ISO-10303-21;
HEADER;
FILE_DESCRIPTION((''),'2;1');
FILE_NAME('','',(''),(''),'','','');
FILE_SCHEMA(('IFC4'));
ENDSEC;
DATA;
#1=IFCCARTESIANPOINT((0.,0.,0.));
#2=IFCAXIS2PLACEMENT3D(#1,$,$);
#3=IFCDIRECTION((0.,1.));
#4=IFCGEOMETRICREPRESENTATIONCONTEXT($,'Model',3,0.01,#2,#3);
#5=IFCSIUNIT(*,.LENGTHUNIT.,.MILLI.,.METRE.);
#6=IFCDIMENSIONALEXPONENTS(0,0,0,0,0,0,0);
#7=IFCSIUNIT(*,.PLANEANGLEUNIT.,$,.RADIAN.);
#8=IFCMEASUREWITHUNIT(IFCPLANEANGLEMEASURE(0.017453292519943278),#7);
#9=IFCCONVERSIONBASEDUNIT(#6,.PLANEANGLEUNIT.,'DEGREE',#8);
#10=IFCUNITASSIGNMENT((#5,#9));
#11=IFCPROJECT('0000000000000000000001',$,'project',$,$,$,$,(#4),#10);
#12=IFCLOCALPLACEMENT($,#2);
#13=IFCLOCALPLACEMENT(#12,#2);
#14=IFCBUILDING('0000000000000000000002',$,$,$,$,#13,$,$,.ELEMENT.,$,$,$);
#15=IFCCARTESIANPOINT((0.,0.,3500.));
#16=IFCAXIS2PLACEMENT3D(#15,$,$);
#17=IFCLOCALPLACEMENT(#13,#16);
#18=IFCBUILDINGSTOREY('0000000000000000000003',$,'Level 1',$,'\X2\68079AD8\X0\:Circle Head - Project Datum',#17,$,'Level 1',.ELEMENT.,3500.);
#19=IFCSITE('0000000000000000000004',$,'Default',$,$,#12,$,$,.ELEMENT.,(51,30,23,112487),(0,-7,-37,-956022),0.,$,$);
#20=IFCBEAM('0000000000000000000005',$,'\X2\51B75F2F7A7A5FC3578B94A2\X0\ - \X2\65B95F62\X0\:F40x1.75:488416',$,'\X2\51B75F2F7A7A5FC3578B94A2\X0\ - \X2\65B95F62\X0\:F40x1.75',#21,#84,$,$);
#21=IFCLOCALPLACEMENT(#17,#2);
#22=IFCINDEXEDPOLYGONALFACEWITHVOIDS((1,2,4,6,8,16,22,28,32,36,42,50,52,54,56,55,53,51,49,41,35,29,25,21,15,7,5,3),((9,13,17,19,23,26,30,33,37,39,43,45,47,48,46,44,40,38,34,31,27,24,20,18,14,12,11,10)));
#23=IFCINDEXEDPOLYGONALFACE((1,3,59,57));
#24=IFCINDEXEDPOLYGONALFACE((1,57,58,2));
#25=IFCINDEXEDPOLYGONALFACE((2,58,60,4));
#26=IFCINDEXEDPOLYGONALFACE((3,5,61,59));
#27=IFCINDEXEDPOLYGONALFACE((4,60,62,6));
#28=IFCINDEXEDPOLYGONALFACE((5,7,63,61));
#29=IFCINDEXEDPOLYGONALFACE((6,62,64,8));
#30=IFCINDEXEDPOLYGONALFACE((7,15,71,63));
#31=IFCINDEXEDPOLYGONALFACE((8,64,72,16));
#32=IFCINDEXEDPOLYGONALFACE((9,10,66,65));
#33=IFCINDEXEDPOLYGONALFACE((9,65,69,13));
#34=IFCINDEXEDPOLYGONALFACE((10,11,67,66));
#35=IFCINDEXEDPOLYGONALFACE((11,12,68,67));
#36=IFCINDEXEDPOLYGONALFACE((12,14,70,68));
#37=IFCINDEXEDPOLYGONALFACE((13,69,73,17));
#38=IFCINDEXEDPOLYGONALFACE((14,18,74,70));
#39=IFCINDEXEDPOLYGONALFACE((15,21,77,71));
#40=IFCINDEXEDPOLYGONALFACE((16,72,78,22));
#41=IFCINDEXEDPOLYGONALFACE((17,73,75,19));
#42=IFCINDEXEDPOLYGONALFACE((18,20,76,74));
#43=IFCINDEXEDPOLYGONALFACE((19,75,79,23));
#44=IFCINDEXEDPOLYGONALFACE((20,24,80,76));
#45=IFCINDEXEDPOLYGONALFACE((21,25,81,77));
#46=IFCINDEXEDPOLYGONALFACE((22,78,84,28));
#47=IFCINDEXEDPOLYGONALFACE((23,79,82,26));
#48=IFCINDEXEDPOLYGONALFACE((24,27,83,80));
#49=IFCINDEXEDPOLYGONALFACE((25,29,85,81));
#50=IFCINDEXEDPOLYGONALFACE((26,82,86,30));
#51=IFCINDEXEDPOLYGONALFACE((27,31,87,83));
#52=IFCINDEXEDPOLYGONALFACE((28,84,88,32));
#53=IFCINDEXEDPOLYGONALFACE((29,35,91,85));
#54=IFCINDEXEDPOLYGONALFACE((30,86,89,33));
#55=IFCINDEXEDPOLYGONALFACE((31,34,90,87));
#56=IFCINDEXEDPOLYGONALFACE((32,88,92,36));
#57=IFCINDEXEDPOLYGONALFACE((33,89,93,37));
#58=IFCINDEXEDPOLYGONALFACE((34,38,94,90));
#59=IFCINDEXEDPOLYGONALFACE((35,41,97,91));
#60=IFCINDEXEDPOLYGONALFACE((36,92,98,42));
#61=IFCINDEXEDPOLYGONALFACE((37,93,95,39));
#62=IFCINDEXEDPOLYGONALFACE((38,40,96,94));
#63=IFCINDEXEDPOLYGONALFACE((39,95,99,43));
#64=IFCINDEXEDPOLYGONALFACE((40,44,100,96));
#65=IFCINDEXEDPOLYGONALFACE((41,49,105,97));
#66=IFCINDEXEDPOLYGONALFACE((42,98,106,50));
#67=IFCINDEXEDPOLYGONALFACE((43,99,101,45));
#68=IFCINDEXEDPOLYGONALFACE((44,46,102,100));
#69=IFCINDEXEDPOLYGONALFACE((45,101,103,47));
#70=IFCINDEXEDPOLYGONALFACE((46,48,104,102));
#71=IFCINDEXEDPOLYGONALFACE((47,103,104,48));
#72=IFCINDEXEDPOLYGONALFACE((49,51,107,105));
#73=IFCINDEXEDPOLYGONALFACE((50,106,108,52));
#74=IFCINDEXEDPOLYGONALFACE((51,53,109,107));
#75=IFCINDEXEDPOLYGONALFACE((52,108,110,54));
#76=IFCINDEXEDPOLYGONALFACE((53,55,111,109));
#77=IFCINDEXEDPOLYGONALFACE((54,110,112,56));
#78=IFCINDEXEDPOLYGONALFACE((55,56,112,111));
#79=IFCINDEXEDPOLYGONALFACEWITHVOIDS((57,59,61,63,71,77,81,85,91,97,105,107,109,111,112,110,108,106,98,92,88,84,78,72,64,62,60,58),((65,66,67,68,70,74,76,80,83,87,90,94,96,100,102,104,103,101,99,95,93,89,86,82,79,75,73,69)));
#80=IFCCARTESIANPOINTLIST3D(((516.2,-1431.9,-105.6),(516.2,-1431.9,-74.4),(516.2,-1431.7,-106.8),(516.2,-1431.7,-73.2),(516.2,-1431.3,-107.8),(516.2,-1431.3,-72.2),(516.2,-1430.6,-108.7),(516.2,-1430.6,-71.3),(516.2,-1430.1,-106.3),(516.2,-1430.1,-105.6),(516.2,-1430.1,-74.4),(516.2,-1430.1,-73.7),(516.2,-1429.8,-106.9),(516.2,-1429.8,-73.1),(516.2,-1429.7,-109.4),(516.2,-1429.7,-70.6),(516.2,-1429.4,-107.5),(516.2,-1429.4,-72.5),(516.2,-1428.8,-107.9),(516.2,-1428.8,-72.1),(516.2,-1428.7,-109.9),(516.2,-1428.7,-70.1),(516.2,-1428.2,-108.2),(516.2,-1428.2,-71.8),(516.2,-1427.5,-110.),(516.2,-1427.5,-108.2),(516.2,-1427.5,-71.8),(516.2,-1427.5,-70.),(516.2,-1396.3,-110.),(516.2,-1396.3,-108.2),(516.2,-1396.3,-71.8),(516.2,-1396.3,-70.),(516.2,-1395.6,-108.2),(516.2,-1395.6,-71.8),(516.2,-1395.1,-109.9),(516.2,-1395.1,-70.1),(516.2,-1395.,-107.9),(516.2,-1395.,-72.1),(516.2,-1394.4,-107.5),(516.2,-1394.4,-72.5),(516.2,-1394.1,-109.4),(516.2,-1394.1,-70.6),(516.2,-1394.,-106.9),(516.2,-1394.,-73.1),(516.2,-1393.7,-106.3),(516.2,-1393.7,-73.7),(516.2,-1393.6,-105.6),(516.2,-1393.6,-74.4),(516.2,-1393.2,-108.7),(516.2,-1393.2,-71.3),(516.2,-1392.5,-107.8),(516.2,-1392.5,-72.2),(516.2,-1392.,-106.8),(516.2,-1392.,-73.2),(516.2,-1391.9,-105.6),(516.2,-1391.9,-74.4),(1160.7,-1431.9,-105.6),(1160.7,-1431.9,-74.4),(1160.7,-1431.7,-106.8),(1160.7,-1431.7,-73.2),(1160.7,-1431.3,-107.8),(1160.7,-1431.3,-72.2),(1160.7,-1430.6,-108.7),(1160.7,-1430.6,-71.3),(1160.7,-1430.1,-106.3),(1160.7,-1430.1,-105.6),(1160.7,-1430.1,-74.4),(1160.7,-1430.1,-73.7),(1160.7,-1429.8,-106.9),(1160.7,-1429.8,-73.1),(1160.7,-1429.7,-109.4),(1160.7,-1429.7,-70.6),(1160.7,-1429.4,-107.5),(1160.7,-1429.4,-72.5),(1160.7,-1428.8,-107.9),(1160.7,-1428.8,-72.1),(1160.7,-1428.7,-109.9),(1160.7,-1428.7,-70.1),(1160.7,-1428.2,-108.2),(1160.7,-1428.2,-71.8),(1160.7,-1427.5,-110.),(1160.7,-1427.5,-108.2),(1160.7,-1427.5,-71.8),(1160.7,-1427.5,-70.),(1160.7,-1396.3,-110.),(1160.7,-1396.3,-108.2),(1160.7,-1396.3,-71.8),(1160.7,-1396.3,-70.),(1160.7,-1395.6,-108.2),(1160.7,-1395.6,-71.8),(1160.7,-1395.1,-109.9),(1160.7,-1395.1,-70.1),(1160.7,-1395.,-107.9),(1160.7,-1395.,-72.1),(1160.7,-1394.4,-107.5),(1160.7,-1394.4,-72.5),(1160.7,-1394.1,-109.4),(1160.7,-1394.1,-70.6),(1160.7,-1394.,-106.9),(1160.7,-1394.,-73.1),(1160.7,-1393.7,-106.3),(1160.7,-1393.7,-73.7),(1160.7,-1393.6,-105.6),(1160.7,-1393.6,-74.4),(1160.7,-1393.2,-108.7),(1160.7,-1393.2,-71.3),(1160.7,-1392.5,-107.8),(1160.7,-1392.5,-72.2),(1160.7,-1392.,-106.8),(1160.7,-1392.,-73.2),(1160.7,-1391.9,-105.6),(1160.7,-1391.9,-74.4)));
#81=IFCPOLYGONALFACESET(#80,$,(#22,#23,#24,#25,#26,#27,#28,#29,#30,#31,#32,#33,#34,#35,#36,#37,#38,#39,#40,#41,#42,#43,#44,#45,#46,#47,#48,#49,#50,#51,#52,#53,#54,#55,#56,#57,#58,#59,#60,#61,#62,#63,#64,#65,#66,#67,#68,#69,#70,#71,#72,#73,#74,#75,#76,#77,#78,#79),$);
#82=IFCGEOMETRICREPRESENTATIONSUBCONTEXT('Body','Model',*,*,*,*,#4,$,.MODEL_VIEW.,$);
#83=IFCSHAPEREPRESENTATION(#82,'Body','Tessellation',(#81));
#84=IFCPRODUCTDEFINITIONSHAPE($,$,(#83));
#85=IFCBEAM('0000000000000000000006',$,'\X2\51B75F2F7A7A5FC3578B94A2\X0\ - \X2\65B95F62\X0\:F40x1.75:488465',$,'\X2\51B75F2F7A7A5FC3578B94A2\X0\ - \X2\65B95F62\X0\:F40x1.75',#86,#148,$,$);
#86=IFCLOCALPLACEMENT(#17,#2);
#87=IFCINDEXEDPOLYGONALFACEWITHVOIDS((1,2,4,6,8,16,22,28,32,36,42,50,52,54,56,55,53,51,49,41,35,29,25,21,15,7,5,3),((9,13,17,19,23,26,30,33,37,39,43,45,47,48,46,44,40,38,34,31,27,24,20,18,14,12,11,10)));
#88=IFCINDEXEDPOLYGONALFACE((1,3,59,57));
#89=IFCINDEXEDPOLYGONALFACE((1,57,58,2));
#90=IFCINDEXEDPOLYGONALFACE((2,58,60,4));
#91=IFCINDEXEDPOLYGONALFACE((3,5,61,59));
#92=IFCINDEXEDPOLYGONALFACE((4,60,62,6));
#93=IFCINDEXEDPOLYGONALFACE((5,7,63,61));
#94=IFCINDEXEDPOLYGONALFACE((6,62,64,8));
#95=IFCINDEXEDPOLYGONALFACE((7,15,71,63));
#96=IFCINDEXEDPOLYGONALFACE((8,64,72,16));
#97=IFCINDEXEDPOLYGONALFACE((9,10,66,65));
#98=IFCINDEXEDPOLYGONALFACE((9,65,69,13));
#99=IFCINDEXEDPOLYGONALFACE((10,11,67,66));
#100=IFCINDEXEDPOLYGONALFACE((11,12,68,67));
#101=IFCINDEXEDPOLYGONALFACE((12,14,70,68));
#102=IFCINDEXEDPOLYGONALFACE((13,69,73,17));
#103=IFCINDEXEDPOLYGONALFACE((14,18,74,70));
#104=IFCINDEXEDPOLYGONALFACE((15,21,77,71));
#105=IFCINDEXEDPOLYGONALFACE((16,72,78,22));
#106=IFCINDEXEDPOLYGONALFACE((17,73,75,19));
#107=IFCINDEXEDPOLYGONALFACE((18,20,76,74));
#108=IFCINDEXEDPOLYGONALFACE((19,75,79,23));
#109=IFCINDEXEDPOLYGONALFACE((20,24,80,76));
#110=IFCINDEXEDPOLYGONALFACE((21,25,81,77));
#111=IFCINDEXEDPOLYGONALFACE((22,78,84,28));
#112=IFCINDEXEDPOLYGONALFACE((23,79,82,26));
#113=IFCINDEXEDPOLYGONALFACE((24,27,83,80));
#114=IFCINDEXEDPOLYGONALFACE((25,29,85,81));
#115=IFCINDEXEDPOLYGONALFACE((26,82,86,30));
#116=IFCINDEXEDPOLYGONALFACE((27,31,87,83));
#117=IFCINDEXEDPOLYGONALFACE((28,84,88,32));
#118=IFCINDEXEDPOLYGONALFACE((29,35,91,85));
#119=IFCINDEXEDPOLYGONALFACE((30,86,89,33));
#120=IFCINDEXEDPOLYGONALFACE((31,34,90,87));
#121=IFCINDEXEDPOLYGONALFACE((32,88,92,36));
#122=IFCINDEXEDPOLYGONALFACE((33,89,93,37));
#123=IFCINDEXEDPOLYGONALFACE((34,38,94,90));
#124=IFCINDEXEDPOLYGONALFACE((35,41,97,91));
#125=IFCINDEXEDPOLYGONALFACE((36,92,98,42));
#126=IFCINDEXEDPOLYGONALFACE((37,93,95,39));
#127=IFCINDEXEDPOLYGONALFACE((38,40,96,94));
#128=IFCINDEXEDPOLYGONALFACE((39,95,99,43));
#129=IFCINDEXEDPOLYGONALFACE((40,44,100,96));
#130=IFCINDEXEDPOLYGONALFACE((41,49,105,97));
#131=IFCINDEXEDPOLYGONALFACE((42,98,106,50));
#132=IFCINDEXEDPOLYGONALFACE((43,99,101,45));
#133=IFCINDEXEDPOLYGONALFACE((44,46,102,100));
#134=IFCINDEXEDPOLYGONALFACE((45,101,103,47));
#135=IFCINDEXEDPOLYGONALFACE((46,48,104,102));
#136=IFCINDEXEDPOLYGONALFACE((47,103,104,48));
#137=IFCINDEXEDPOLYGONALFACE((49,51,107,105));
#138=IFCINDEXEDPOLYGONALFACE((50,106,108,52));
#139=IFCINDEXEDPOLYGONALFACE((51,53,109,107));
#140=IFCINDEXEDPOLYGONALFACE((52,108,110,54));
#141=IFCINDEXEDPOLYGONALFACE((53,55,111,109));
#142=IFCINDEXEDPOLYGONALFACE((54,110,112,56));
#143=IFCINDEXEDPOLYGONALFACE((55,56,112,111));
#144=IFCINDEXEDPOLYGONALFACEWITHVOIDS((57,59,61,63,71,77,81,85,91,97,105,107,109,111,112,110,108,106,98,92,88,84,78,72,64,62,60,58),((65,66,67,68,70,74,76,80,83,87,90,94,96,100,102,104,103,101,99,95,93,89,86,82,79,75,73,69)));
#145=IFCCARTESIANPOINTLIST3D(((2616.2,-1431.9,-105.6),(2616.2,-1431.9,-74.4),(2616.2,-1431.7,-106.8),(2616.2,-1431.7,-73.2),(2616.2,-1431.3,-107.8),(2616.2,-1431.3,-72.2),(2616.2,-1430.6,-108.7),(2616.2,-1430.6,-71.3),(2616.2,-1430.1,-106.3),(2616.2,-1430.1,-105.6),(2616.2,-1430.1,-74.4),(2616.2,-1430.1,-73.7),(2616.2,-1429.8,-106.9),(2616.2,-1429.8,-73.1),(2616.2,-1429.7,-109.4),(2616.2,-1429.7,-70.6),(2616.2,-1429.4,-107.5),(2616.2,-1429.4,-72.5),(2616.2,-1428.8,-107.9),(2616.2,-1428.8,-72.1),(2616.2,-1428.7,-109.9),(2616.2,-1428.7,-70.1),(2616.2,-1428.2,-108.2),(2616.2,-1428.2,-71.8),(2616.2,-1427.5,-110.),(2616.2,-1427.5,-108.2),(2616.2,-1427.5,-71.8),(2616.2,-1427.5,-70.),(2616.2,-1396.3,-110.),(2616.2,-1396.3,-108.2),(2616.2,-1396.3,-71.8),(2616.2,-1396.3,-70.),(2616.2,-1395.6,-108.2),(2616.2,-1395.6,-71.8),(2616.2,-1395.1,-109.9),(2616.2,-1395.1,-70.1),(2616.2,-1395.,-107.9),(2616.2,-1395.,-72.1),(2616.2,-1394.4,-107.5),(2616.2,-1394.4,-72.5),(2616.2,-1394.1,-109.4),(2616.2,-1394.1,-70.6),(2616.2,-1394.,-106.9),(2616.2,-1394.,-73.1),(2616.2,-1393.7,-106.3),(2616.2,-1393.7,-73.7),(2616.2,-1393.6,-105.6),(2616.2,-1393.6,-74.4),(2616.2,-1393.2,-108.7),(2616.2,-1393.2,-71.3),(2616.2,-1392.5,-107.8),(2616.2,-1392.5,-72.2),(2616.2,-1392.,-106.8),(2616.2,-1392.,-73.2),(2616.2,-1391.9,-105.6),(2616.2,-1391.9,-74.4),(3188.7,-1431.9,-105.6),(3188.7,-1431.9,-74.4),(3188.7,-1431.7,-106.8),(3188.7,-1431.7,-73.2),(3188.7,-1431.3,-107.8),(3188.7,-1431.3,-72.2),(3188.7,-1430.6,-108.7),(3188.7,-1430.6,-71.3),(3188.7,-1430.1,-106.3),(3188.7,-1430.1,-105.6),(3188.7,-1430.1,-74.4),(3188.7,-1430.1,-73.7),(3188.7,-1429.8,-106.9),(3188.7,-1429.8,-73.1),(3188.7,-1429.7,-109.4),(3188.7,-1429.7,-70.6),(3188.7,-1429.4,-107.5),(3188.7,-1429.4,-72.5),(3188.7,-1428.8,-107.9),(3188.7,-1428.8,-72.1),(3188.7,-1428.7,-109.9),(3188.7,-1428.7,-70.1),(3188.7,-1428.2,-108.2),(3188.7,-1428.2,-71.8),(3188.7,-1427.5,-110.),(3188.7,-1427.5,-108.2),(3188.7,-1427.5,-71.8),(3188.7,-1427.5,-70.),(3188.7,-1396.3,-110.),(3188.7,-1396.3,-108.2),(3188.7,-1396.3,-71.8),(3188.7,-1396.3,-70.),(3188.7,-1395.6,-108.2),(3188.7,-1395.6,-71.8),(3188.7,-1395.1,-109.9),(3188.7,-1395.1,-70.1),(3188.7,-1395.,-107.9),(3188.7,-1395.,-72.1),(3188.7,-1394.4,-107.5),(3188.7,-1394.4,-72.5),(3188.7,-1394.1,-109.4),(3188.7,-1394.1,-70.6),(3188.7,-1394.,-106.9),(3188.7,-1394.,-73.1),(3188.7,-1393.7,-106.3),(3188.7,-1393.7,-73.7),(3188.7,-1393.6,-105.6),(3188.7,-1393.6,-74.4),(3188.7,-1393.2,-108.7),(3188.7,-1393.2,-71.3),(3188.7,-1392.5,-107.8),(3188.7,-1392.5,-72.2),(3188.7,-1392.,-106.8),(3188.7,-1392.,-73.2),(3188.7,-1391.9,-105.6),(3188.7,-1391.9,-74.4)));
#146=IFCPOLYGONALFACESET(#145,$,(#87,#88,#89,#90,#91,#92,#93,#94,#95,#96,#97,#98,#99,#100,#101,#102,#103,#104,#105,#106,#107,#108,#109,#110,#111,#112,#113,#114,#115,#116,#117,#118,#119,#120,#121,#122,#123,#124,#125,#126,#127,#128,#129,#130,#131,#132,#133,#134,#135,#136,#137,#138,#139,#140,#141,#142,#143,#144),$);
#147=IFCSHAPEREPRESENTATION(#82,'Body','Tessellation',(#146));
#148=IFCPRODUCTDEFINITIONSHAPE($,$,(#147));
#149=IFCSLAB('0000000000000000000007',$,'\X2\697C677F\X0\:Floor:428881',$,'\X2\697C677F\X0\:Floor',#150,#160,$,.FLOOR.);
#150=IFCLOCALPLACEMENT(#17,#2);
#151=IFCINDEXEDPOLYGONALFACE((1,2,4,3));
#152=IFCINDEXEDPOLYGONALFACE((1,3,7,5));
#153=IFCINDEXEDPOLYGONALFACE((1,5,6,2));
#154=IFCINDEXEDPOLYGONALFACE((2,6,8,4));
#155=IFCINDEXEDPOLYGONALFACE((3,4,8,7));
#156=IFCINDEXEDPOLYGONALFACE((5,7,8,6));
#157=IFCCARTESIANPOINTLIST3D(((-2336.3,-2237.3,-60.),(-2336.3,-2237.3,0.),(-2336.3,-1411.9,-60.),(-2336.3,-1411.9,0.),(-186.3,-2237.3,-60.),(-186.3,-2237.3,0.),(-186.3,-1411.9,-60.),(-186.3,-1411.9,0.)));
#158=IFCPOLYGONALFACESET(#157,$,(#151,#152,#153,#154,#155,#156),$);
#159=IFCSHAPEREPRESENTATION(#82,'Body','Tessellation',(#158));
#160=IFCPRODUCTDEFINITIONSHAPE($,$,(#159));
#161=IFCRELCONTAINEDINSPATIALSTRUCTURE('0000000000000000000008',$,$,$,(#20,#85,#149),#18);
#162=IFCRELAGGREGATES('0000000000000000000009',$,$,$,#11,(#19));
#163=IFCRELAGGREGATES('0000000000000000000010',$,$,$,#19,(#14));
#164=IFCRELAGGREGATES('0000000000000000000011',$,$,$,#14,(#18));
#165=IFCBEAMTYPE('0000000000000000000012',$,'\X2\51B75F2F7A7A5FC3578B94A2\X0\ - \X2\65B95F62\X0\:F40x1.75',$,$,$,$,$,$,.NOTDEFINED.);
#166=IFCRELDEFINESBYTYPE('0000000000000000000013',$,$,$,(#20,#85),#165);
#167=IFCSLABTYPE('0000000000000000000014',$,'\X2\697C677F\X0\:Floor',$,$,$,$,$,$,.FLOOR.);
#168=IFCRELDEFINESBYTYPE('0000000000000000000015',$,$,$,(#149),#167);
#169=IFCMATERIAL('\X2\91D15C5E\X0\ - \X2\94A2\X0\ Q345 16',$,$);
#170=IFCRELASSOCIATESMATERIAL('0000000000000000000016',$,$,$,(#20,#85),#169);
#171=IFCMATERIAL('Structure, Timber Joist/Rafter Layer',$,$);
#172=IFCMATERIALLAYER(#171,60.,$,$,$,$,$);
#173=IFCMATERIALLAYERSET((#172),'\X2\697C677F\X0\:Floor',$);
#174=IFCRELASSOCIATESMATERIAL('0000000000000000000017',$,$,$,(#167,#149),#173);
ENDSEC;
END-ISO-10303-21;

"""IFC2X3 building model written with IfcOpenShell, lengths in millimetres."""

from ifc_helpers import new_model, entity, si_unit, converted_unit, direction, frame, frame_2d, origin, place, context, subcontext, project, spatial, polyline, circle_curve, parameter, trimmed, segment, composite_curve, rectangle, outline, extrude, material, layer, layer_set, layer_usage, type_object, element, save


model = new_model("IFC2X3")

# Units and contexts
model_context = context("Model", 3, precision=0.01, world=origin(), true_north=direction((0.0, 1.0)))
body_context = subcontext(model_context, "Body", "Model", "MODEL_VIEW")
ifc_project = project(units=[si_unit("LENGTHUNIT", "METRE", prefix="MILLI"), converted_unit("PLANEANGLEUNIT", "DEGREE", entity("IfcPlaneAngleMeasure", 0.017453292519943278), si_unit("PLANEANGLEUNIT", "RADIAN"), dimensions=[0, 0, 0, 0, 0, 0, 0])], contexts=[model_context])

# Site, building, storey
site_placement = place(None, origin())
site = spatial("IfcSite", under=ifc_project, at=site_placement, Name="Default", CompositionType="ELEMENT", RefLatitude=(51, 30, 23, 112487), RefLongitude=(0, -7, -37, -956022), RefElevation=0.0)
building_placement = place(site_placement, origin())
building = spatial("IfcBuilding", under=site, at=building_placement, CompositionType="ELEMENT")
storey_placement = place(building_placement, frame((0.0, 0.0, 3500.0)))
storey = spatial("IfcBuildingStorey", under=building, at=storey_placement, Name="Level 1", ObjectType="标高:Circle Head - Project Datum", LongName="Level 1", CompositionType="ELEMENT", Elevation=3500.0)

# Beams
ifc_material_1 = material(Name="金属 - 钢 Q345 16")
beam_type_1 = type_object("IfcBeamType", Name="冷弯空心型钢 - 方形:F40x1.75", PredefinedType="NOTDEFINED")
beam_1_placement = place(storey_placement, frame((548.7, -1411.9, -70.0)))
element("IfcBeam", 1, at=beam_1_placement, inside=storey, type_object=beam_type_1, material=ifc_material_1, Name="冷弯空心型钢 - 方形:F40x1.75:488416", ObjectType="冷弯空心型钢 - 方形:F40x1.75", context=body_context, shape_type="SweptSolid", body=[
    extrude(outline(composite_curve([segment(trimmed(circle_curve(frame_2d((-15.6, 15.6), x_axis=(1.0, 0.0)), 4.4), [parameter(90.0)], [parameter(180.0)], True, "PARAMETER"), True, "CONTINUOUS"), segment(polyline([(-20.0, 15.6), (-20.0, -15.6)]), True, "CONTINUOUS"), segment(trimmed(circle_curve(frame_2d((-15.6, -15.6), x_axis=(1.0, 0.0)), 4.4), [parameter(180.0)], [parameter(270.0)], True, "PARAMETER"), True, "CONTINUOUS"), segment(polyline([(-15.6, -20.0), (15.6, -20.0)]), True, "CONTINUOUS"), segment(trimmed(circle_curve(frame_2d((15.6, -15.6), x_axis=(1.0, 0.0)), 4.4), [parameter(270.0)], [parameter(0.0)], True, "PARAMETER"), True, "CONTINUOUS"), segment(polyline([(20.0, -15.6), (20.0, 15.6)]), True, "CONTINUOUS"), segment(trimmed(circle_curve(frame_2d((15.6, 15.6), x_axis=(1.0, 0.0)), 4.4), [parameter(0.0)], [parameter(90.0)], True, "PARAMETER"), True, "CONTINUOUS"), segment(polyline([(15.6, 20.0), (-15.6, 20.0)]), True, "CONTINUOUS")], self_intersect=False), holes=[composite_curve([segment(polyline([(-15.6, 18.3), (15.6, 18.3)]), True, "CONTINUOUS"), segment(trimmed(circle_curve(frame_2d((15.6, 15.6), x_axis=(1.0, 0.0)), 2.6), [parameter(0.0)], [parameter(90.0)], True, "PARAMETER"), False, "CONTINUOUS"), segment(polyline([(18.2, 15.6), (18.2, -15.6)]), True, "CONTINUOUS"), segment(trimmed(circle_curve(frame_2d((15.6, -15.6), x_axis=(1.0, 0.0)), 2.6), [parameter(270.0)], [parameter(360.0)], True, "PARAMETER"), False, "CONTINUOUS"), segment(polyline([(15.6, -18.3), (-15.6, -18.3)]), True, "CONTINUOUS"), segment(trimmed(circle_curve(frame_2d((-15.6, -15.6), x_axis=(1.0, 0.0)), 2.6), [parameter(180.0)], [parameter(270.0)], True, "PARAMETER"), False, "CONTINUOUS"), segment(polyline([(-18.3, -15.6), (-18.3, 15.6)]), True, "CONTINUOUS"), segment(trimmed(circle_curve(frame_2d((-15.6, 15.6), x_axis=(1.0, 0.0)), 2.6), [parameter(90.0)], [parameter(180.0)], True, "PARAMETER"), False, "CONTINUOUS")], self_intersect=False)]), frame((-32.5, 0.0, -20.0), z_axis=(1.0, 0.0, 0.0), x_axis=(0.0, 1.0, 0.0)), (0.0, 0.0, 1.0), 644.5),
])
beam_2_placement = place(storey_placement, frame((2618.7, -1411.9, -70.0)))
element("IfcBeam", 2, at=beam_2_placement, inside=storey, type_object=beam_type_1, material=ifc_material_1, Name="冷弯空心型钢 - 方形:F40x1.75:488465", ObjectType="冷弯空心型钢 - 方形:F40x1.75", context=body_context, shape_type="SweptSolid", body=[
    extrude(outline(composite_curve([segment(trimmed(circle_curve(frame_2d((-15.6, 15.6), x_axis=(1.0, 0.0)), 4.4), [parameter(90.0)], [parameter(180.0)], True, "PARAMETER"), True, "CONTINUOUS"), segment(polyline([(-20.0, 15.6), (-20.0, -15.6)]), True, "CONTINUOUS"), segment(trimmed(circle_curve(frame_2d((-15.6, -15.6), x_axis=(1.0, 0.0)), 4.4), [parameter(180.0)], [parameter(270.0)], True, "PARAMETER"), True, "CONTINUOUS"), segment(polyline([(-15.6, -20.0), (15.6, -20.0)]), True, "CONTINUOUS"), segment(trimmed(circle_curve(frame_2d((15.6, -15.6), x_axis=(1.0, 0.0)), 4.4), [parameter(270.0)], [parameter(0.0)], True, "PARAMETER"), True, "CONTINUOUS"), segment(polyline([(20.0, -15.6), (20.0, 15.6)]), True, "CONTINUOUS"), segment(trimmed(circle_curve(frame_2d((15.6, 15.6), x_axis=(1.0, 0.0)), 4.4), [parameter(0.0)], [parameter(90.0)], True, "PARAMETER"), True, "CONTINUOUS"), segment(polyline([(15.6, 20.0), (-15.6, 20.0)]), True, "CONTINUOUS")], self_intersect=False), holes=[composite_curve([segment(polyline([(-15.6, 18.3), (15.6, 18.3)]), True, "CONTINUOUS"), segment(trimmed(circle_curve(frame_2d((15.6, 15.6), x_axis=(1.0, 0.0)), 2.6), [parameter(0.0)], [parameter(90.0)], True, "PARAMETER"), False, "CONTINUOUS"), segment(polyline([(18.2, 15.6), (18.2, -15.6)]), True, "CONTINUOUS"), segment(trimmed(circle_curve(frame_2d((15.6, -15.6), x_axis=(1.0, 0.0)), 2.6), [parameter(270.0)], [parameter(360.0)], True, "PARAMETER"), False, "CONTINUOUS"), segment(polyline([(15.6, -18.3), (-15.6, -18.3)]), True, "CONTINUOUS"), segment(trimmed(circle_curve(frame_2d((-15.6, -15.6), x_axis=(1.0, 0.0)), 2.6), [parameter(180.0)], [parameter(270.0)], True, "PARAMETER"), False, "CONTINUOUS"), segment(polyline([(-18.3, -15.6), (-18.3, 15.6)]), True, "CONTINUOUS"), segment(trimmed(circle_curve(frame_2d((-15.6, 15.6), x_axis=(1.0, 0.0)), 2.6), [parameter(90.0)], [parameter(180.0)], True, "PARAMETER"), False, "CONTINUOUS")], self_intersect=False)]), frame((-2.5, 0.0, -20.0), z_axis=(1.0, 0.0, 0.0), x_axis=(0.0, 1.0, 0.0)), (0.0, 0.0, 1.0), 572.5),
])

# Slab
ifc_material_2 = material(Name="Structure, Timber Joist/Rafter Layer")
ifc_layer = layer(ifc_material_2, 60.0)
ifc_layer_set = layer_set([ifc_layer], Name="楼板:Floor")
ifc_layer_usage_1 = layer_usage(ifc_layer_set, "AXIS3", "POSITIVE", 0.0)
slab_type = type_object("IfcSlabType", Name="楼板:Floor", PredefinedType="FLOOR", material=ifc_layer_set)
slab_1_placement = place(storey_placement, origin())
element("IfcSlab", 3, at=slab_1_placement, inside=storey, type_object=slab_type, material=ifc_layer_usage_1, Name="楼板:Floor:428881", ObjectType="楼板:Floor", PredefinedType="FLOOR", context=body_context, shape_type="SweptSolid", body=[
    extrude(rectangle(XDim=825.4, YDim=2150.0, at=frame_2d((0.0, 0.0), x_axis=(1.0, 0.0))), frame((-1261.3, -1824.6, 0.0), z_axis=(0.0, 0.0, -1.0), x_axis=(0.0, 1.0, 0.0)), (0.0, 0.0, 1.0), 60.0),
])

save(model, "model.ifc")
